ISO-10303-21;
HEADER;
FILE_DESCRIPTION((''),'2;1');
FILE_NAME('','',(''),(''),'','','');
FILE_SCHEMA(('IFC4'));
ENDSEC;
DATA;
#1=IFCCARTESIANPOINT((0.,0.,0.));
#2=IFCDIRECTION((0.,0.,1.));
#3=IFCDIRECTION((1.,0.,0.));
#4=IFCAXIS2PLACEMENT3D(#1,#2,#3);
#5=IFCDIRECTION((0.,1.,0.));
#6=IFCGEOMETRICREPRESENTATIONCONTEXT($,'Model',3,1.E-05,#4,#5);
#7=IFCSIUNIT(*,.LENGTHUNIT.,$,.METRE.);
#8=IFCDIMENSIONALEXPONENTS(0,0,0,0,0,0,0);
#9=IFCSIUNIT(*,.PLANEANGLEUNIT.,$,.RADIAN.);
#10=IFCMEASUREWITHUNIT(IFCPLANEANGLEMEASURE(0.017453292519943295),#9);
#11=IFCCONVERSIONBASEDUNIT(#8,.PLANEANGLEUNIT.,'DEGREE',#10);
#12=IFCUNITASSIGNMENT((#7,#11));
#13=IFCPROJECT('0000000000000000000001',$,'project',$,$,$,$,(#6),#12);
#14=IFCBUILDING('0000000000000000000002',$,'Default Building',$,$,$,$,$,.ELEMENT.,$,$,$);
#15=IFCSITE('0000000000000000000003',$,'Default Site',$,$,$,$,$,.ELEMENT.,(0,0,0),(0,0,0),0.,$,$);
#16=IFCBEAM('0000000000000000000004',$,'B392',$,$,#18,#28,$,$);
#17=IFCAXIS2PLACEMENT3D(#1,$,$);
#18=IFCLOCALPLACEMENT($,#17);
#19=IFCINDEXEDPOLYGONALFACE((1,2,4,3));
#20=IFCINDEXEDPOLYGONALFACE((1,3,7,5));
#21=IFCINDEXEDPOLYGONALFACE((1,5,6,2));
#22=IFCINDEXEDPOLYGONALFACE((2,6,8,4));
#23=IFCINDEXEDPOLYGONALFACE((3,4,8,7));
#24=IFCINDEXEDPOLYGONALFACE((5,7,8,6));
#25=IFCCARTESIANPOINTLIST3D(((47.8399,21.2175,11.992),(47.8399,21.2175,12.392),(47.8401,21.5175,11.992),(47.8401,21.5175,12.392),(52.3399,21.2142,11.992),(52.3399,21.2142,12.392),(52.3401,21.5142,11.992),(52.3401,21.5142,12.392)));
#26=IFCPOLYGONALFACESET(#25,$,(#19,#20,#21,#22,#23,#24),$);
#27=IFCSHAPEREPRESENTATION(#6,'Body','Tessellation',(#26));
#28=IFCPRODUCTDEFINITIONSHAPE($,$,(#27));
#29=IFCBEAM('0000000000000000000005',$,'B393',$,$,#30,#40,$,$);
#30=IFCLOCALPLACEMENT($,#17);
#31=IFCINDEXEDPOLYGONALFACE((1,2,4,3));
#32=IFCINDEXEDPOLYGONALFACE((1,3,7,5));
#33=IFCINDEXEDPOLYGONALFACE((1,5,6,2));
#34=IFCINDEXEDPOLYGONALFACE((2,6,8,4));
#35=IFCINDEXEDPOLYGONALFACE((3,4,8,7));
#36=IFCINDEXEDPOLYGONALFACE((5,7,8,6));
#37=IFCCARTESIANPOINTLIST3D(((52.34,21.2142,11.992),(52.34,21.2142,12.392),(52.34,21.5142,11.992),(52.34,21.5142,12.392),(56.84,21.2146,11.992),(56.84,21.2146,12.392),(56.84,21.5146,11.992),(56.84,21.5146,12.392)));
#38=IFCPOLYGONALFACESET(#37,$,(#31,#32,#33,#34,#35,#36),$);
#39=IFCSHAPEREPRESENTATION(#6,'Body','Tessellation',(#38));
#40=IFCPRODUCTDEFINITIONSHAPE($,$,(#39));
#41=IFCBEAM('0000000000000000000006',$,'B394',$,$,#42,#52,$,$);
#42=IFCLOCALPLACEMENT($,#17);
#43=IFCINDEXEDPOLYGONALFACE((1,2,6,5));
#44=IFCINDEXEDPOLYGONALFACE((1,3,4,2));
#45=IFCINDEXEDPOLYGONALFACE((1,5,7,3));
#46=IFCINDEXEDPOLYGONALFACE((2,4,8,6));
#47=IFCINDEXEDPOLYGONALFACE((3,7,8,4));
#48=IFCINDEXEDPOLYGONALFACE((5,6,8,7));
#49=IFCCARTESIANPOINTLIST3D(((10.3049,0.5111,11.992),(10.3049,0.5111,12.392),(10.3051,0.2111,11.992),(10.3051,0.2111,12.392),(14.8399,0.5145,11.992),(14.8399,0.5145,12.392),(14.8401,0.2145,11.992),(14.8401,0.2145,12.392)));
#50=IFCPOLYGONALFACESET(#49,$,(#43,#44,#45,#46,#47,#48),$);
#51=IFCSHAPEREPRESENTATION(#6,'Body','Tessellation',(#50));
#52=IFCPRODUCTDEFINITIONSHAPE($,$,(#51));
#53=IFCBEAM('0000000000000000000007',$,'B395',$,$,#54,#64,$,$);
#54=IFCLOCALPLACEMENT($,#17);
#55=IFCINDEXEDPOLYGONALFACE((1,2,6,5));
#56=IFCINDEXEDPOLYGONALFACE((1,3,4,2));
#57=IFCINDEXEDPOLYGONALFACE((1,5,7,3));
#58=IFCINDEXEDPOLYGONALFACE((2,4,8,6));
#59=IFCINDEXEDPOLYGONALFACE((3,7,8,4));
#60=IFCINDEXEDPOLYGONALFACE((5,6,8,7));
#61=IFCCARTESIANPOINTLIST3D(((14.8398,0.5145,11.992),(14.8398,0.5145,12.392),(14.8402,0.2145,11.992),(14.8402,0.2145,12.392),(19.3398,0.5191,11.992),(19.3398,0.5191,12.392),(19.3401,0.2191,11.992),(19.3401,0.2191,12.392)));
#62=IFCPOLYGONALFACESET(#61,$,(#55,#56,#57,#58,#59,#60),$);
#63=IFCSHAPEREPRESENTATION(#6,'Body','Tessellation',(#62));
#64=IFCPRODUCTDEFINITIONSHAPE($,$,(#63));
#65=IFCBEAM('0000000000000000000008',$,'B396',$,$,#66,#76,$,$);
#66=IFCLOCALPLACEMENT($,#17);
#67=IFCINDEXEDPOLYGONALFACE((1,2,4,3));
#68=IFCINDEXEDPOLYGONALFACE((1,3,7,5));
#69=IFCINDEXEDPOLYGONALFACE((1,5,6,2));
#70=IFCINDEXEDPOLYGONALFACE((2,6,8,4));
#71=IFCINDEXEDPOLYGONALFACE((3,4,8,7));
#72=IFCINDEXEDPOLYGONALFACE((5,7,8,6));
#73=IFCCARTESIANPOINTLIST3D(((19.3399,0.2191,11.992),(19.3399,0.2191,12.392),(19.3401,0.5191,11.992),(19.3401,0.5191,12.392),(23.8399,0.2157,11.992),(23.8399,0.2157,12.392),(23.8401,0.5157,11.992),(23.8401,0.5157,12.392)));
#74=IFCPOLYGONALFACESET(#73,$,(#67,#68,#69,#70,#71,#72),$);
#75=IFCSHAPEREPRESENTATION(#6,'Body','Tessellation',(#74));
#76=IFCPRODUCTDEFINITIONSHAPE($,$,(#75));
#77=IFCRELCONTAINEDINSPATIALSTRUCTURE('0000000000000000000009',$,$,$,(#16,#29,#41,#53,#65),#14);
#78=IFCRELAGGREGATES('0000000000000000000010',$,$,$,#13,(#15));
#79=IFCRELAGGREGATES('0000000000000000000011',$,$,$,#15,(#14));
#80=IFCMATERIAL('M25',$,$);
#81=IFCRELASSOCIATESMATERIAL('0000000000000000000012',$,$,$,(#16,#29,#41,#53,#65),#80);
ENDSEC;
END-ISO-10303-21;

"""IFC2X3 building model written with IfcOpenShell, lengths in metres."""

from ifc_helpers import new_model, entity, si_unit, converted_unit, direction, frame, frame_2d, origin_with_axes, place, context, project, spatial, rectangle, extrude, material, element, save


model = new_model("IFC2X3")

# Units and contexts
model_context = context("Model", 3, precision=1e-05, world=origin_with_axes(), true_north=direction((0.0, 1.0, 0.0)))
ifc_project = project(units=[si_unit("LENGTHUNIT", "METRE"), converted_unit("PLANEANGLEUNIT", "DEGREE", entity("IfcPlaneAngleMeasure", 0.017453292519943295), si_unit("PLANEANGLEUNIT", "RADIAN"), dimensions=[0, 0, 0, 0, 0, 0, 0])], contexts=[model_context])

# Site, building
site = spatial("IfcSite", under=ifc_project, Name="Default Site", CompositionType="ELEMENT", RefLatitude=(0, 0, 0), RefLongitude=(0, 0, 0), RefElevation=0.0)
building = spatial("IfcBuilding", under=site, Name="Default Building", CompositionType="ELEMENT")

# Shared definitions
ifc_material = material(Name="M25")
placement = place(None, origin_with_axes())

# Beams
element("IfcBeam", 1, at=placement, inside=building, material=ifc_material, Name="B392", context=model_context, shape_type="SweptSolid", body=[
    extrude(rectangle(XDim=0.3, YDim=0.4, at=frame_2d((0.0, 0.0), x_axis=(0.0, 1.0, 0.0))), frame((47.84, 21.3675, 12.192), z_axis=(1.0, -0.000744, 0.0), x_axis=(0.0, 0.0, -1.0)), (0.0, 0.0, 1.0), 4.5),
])
element("IfcBeam", 2, at=placement, inside=building, material=ifc_material, Name="B393", context=model_context, shape_type="SweptSolid", body=[
    extrude(rectangle(XDim=0.3, YDim=0.4, at=frame_2d((0.0, 0.0), x_axis=(0.0, 1.0, 0.0))), frame((52.34, 21.3642, 12.192), z_axis=(1.0, 0.000102, 0.0), x_axis=(0.0, 0.0, -1.0)), (0.0, 0.0, 1.0), 4.5),
])
element("IfcBeam", 3, at=placement, inside=building, material=ifc_material, Name="B394", context=model_context, shape_type="SweptSolid", body=[
    extrude(rectangle(XDim=0.3, YDim=0.4, at=frame_2d((0.0, 0.0), x_axis=(0.0, 1.0, 0.0))), frame((10.305, 0.3611, 12.192), z_axis=(1.0, 0.000762, 0.0), x_axis=(0.0, 0.0, -1.0)), (0.0, 0.0, 1.0), 4.535),
])
element("IfcBeam", 4, at=placement, inside=building, material=ifc_material, Name="B395", context=model_context, shape_type="SweptSolid", body=[
    extrude(rectangle(XDim=0.3, YDim=0.4, at=frame_2d((0.0, 0.0), x_axis=(0.0, 1.0, 0.0))), frame((14.84, 0.3645, 12.192), z_axis=(0.999999, 0.00101, 0.0), x_axis=(0.0, 0.0, -1.0)), (0.0, 0.0, 1.0), 4.5),
])
element("IfcBeam", 5, at=placement, inside=building, material=ifc_material, Name="B396", context=model_context, shape_type="SweptSolid", body=[
    extrude(rectangle(XDim=0.3, YDim=0.4, at=frame_2d((0.0, 0.0), x_axis=(0.0, 1.0, 0.0))), frame((19.34, 0.3691, 12.192), z_axis=(1.0, -0.000757, 0.0), x_axis=(0.0, 0.0, -1.0)), (0.0, 0.0, 1.0), 4.5),
])

save(model, "model.ifc")
